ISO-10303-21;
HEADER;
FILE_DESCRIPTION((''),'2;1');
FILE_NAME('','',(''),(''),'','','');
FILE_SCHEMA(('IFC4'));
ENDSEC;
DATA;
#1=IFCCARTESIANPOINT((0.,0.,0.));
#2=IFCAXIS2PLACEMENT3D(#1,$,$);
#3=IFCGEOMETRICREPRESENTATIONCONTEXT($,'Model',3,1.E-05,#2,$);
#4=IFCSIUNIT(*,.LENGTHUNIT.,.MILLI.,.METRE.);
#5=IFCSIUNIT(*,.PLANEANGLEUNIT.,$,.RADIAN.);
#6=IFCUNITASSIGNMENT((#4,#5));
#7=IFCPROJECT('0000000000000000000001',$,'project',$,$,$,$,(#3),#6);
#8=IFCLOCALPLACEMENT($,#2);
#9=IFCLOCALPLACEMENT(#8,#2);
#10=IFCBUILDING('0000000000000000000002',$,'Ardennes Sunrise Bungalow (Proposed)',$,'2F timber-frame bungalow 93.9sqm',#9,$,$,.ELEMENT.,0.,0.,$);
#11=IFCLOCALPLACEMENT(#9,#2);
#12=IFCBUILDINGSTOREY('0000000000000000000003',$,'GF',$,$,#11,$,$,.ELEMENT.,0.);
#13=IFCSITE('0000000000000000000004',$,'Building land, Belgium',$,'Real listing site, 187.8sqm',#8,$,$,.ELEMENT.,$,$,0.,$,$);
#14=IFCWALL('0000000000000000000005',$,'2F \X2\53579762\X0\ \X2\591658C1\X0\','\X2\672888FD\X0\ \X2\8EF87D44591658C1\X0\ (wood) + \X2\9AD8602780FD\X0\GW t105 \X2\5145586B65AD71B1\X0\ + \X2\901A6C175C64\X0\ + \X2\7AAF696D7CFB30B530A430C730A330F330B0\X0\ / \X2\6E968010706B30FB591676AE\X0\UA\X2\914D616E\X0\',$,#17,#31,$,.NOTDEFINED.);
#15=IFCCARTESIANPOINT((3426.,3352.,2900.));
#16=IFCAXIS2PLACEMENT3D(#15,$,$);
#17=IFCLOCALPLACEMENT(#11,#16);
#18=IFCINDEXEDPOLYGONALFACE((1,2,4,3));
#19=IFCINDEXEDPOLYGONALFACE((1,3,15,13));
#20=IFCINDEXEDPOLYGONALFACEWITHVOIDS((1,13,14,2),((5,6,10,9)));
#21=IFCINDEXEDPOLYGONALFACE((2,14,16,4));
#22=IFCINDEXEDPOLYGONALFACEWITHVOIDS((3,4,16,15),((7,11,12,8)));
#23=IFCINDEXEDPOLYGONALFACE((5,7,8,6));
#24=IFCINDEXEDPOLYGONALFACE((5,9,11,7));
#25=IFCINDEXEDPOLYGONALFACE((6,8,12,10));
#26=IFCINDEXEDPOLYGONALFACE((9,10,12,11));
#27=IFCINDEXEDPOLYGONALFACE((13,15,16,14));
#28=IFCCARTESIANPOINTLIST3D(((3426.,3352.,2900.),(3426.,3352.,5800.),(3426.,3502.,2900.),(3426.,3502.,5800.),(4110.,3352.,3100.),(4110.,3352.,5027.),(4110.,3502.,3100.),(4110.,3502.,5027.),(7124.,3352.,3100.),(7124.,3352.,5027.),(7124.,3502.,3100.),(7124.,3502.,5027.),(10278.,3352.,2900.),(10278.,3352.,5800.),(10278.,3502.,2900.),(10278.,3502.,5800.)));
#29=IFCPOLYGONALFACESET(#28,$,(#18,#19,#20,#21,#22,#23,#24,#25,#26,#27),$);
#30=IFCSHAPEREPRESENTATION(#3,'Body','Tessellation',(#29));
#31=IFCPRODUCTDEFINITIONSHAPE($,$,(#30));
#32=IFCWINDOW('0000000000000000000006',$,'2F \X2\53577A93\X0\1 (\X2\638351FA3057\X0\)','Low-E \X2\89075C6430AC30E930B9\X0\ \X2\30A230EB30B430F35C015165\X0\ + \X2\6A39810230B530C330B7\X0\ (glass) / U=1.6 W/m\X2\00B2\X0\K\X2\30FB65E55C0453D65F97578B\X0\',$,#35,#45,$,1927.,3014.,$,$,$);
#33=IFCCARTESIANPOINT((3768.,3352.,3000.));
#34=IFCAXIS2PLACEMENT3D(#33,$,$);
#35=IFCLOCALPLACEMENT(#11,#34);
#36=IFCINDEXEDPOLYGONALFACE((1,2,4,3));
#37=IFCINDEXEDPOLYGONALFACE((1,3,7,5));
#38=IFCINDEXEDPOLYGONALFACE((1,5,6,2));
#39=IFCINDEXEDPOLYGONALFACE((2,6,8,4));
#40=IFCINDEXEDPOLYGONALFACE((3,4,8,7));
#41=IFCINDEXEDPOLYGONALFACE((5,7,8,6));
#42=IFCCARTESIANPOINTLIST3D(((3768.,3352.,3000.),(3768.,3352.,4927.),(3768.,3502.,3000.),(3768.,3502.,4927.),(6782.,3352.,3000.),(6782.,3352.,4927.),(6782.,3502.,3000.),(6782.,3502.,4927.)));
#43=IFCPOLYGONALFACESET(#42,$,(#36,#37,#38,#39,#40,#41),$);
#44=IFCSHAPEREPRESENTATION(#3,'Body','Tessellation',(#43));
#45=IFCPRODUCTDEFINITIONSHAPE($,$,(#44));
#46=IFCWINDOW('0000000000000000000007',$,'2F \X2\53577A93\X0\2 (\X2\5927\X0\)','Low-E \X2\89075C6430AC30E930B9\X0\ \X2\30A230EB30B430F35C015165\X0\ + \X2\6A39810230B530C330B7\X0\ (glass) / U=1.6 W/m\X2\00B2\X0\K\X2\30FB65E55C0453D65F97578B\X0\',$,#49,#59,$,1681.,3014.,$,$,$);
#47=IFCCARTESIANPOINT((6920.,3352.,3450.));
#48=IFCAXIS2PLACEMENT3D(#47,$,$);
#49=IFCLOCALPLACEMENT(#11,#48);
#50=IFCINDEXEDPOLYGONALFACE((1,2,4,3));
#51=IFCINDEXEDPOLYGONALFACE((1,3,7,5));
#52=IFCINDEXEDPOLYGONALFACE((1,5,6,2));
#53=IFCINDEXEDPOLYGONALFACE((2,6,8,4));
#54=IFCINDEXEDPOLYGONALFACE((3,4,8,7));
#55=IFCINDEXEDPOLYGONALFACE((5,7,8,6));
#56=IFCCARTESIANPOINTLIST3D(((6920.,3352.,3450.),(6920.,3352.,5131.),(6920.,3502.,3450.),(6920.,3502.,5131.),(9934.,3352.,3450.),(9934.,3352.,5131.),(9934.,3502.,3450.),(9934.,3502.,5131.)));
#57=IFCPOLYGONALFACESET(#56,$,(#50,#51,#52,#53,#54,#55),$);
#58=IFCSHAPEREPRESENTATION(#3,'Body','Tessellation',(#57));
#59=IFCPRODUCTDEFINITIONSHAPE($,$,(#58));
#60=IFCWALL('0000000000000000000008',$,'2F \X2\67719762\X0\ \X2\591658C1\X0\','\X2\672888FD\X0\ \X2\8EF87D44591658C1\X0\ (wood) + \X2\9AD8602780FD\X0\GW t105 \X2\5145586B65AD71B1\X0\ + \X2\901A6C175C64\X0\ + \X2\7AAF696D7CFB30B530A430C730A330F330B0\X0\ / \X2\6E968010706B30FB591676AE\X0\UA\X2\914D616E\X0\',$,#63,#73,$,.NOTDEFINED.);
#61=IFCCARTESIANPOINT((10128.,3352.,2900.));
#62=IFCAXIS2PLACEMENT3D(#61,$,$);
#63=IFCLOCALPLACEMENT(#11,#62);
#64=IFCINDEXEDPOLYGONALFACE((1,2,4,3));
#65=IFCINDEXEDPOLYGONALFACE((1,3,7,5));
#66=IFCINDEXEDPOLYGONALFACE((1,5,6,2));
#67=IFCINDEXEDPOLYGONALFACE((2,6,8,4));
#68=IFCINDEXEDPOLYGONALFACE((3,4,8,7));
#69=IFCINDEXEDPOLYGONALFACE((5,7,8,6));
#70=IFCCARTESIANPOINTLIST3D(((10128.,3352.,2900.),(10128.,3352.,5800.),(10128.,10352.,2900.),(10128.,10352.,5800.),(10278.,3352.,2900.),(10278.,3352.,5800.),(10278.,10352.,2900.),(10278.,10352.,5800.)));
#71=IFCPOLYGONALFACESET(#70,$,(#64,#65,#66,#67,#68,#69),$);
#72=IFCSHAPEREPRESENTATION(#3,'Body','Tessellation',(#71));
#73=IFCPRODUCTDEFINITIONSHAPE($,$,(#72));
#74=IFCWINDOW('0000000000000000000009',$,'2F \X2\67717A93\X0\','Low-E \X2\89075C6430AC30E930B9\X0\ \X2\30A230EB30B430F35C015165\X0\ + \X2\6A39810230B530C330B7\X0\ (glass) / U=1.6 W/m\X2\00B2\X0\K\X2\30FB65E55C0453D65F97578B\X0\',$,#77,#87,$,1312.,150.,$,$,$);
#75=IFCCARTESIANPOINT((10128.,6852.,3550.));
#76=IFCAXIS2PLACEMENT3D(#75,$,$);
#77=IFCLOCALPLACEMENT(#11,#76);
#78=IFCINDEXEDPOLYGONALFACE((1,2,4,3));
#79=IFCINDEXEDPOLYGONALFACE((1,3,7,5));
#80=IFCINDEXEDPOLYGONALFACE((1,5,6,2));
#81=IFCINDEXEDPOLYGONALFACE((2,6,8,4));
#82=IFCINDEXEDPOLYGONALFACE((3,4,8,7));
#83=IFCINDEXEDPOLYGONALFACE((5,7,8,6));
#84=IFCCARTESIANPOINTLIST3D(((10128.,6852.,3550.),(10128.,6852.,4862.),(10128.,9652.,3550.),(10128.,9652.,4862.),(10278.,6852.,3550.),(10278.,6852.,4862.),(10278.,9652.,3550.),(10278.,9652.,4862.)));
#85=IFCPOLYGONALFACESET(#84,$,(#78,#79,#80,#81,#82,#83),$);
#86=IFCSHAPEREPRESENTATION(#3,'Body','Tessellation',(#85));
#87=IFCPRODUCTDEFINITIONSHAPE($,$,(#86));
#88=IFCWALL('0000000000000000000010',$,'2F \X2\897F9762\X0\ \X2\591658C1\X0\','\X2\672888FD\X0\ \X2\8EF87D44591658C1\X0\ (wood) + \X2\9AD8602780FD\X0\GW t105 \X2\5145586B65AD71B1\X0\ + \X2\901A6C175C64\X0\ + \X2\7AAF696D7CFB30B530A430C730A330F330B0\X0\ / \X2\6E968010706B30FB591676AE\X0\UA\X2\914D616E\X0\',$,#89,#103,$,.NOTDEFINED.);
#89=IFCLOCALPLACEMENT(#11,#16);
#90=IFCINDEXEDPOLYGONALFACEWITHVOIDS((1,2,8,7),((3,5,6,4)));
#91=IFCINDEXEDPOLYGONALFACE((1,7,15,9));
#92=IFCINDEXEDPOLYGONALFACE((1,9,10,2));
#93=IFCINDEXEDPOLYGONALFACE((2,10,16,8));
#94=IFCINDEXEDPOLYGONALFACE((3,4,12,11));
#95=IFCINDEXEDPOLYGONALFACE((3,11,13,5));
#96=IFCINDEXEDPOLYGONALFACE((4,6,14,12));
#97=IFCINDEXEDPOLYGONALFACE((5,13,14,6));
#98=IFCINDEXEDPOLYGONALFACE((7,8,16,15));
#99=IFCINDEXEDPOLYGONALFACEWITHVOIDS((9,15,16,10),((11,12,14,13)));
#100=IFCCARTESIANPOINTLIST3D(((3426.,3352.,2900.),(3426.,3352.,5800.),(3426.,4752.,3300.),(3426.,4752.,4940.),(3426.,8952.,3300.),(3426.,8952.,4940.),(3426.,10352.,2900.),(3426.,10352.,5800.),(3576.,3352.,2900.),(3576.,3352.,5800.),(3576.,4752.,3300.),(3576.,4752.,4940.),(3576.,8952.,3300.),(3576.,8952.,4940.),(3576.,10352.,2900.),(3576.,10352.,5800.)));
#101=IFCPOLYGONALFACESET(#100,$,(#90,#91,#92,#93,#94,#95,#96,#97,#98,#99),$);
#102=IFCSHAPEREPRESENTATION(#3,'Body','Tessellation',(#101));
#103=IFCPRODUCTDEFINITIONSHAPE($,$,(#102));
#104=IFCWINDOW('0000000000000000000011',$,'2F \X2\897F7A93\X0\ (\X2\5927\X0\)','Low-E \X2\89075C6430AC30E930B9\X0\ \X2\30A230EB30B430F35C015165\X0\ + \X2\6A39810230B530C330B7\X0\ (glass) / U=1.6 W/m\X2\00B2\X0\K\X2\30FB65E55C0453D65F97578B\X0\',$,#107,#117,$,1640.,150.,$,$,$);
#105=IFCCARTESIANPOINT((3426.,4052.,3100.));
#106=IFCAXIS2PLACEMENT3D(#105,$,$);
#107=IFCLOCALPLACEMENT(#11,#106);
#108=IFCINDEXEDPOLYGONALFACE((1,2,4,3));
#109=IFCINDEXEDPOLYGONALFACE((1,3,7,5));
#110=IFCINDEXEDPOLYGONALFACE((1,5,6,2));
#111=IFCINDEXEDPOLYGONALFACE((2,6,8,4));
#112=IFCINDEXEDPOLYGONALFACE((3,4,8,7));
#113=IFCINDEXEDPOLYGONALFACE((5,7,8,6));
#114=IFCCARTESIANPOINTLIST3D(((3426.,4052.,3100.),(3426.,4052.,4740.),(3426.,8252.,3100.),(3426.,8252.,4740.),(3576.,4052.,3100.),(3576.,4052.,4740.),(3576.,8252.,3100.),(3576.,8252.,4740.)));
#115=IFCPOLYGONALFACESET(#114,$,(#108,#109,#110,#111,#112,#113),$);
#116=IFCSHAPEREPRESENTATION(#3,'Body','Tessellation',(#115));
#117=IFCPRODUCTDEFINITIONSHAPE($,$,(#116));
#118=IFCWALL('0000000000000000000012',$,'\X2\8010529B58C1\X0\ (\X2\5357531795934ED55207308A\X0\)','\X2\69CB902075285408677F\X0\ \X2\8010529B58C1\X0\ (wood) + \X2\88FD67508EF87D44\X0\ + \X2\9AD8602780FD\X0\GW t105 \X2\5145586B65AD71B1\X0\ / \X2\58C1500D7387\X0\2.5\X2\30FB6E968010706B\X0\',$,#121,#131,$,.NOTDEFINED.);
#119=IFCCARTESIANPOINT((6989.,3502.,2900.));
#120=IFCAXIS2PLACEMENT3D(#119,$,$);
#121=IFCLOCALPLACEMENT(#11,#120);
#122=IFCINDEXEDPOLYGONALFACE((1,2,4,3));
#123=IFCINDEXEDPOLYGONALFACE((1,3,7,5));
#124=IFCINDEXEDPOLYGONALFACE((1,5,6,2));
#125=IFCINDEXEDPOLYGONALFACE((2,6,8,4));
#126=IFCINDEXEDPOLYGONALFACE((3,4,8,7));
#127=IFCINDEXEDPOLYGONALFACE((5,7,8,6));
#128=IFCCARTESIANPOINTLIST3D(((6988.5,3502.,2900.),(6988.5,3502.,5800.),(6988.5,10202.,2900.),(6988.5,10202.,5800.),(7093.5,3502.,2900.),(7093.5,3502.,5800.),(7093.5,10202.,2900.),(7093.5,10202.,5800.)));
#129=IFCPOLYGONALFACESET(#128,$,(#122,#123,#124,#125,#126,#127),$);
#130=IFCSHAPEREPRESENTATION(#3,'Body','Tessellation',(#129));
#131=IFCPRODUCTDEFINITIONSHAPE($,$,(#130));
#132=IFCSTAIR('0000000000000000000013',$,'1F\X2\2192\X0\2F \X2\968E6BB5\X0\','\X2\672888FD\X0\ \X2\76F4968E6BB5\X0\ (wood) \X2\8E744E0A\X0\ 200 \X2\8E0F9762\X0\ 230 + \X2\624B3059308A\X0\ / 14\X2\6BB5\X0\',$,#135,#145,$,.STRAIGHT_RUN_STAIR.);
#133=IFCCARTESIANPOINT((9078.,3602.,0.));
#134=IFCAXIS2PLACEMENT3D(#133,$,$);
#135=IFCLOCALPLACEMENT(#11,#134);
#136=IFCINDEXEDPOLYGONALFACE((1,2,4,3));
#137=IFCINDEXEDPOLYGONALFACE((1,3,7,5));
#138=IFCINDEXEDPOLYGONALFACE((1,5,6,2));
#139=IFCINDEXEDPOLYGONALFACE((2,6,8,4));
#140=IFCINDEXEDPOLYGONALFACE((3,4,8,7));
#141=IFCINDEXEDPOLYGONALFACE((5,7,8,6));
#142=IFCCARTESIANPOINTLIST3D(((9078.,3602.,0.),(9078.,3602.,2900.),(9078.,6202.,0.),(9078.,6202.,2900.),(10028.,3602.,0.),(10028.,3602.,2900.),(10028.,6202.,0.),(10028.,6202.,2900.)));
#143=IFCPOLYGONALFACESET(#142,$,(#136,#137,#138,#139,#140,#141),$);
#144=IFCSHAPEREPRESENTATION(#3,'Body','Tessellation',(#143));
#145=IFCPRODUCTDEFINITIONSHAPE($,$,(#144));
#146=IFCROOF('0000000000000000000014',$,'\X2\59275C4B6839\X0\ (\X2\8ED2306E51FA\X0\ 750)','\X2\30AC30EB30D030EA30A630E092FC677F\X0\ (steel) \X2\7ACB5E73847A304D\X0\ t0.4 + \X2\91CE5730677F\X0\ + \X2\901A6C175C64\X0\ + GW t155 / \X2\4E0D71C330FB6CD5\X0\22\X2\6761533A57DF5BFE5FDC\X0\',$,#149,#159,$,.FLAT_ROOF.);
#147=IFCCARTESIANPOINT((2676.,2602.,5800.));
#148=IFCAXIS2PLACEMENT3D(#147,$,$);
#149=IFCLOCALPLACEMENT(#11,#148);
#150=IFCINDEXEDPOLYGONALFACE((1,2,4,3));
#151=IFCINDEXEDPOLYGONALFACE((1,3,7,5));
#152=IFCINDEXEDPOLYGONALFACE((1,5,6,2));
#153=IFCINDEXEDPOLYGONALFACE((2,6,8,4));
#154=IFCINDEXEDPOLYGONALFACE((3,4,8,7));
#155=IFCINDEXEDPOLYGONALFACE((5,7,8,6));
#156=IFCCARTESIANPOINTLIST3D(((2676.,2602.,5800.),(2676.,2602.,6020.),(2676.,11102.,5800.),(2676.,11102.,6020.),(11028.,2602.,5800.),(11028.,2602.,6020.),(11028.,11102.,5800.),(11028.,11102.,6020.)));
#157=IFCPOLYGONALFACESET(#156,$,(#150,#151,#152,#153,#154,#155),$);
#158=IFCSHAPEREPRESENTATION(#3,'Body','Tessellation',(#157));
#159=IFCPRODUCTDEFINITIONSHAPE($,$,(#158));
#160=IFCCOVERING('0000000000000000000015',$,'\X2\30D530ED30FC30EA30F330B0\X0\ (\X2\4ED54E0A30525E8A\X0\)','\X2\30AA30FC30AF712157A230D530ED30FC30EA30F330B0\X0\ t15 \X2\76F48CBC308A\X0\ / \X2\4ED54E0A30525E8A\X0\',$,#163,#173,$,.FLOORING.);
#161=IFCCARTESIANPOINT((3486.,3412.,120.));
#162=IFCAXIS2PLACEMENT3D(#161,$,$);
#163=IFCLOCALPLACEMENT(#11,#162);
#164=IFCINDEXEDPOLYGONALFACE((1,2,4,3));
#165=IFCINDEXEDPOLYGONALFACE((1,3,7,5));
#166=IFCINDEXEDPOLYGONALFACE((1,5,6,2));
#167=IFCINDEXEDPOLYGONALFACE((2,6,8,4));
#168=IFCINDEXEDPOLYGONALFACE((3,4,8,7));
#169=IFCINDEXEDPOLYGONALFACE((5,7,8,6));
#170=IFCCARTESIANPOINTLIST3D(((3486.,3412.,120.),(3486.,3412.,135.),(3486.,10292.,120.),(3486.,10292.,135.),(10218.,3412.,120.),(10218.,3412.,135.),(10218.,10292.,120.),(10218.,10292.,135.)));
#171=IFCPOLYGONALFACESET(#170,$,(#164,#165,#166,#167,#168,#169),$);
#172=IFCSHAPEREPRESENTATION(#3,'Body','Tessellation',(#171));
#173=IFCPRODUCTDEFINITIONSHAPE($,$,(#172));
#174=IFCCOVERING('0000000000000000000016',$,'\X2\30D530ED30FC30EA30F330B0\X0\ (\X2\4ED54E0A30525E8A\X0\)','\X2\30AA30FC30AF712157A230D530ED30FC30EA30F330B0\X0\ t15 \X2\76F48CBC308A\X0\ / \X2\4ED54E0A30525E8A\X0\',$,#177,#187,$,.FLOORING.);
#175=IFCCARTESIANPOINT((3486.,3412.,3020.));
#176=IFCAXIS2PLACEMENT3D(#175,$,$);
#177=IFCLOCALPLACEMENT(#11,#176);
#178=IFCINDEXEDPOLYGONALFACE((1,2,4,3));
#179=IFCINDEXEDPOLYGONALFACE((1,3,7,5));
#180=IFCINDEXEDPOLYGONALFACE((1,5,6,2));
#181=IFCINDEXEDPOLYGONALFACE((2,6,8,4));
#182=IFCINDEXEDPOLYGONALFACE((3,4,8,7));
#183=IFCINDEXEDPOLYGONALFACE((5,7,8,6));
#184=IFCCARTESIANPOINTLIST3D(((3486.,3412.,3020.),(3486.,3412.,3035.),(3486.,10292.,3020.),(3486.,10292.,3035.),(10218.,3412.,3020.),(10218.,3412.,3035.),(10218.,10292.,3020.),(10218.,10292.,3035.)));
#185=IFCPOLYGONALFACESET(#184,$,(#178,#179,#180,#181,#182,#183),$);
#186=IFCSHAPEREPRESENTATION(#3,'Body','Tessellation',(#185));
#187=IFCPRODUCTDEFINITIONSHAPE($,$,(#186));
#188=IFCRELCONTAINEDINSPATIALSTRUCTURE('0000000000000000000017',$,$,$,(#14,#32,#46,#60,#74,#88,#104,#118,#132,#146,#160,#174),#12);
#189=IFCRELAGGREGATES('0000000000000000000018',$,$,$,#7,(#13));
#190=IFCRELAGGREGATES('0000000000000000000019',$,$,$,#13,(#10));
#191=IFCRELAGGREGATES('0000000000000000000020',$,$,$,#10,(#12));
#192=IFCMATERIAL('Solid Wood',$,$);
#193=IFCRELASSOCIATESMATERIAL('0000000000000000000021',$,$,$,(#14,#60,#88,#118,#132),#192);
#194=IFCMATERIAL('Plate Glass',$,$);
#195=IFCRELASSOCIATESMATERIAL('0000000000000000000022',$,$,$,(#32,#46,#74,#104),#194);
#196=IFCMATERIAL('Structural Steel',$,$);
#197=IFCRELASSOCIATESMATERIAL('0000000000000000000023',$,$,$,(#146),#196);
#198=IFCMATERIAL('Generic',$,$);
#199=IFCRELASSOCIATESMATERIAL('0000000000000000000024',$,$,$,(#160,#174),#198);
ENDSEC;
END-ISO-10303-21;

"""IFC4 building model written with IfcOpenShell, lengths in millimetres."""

from ifc_helpers import new_model, si_unit, frame, frame_2d, origin, place, context, project, spatial, rectangle, extrude, material, element, fill, save


model = new_model("IFC4")

# Units and contexts
model_context = context("Model", 3, precision=1e-05, world=origin())
ifc_project = project(units=[si_unit("LENGTHUNIT", "METRE", prefix="MILLI"), si_unit("PLANEANGLEUNIT", "RADIAN")], contexts=[model_context])

# Site, building, storey
site_placement = place(None, origin())
site = spatial("IfcSite", under=ifc_project, at=site_placement, Name="Building land, Belgium", ObjectType="Real listing site, 187.8sqm", CompositionType="ELEMENT", RefElevation=0.0)
building_placement = place(site_placement, origin())
building = spatial("IfcBuilding", under=site, at=building_placement, Name="Ardennes Sunrise Bungalow (Proposed)", ObjectType="2F timber-frame bungalow 93.9sqm", CompositionType="ELEMENT", ElevationOfRefHeight=0.0, ElevationOfTerrain=0.0)
storey_placement = place(building_placement, origin())
storey = spatial("IfcBuildingStorey", under=building, at=storey_placement, Name="GF", CompositionType="ELEMENT", Elevation=0.0)

# Shared definitions
ifc_material_1 = material(Name="Solid Wood")

# Shared definitions
ifc_material_2 = material(Name="Plate Glass")

# Wall, openings, windows
wall_1_placement = place(storey_placement, frame((3426.0, 3352.0, 2900.0)))
wall_1 = element("IfcWall", 1, at=wall_1_placement, inside=storey, material=ifc_material_1, Name="2F 南面 外壁", Description="木製 軸組外壁 (wood) + 高性能GW t105 充填断熱 + 通気層 + 窯業系サイディング / 準耐火・外皮UA配慮", PredefinedType="NOTDEFINED", context=model_context, shape_type="SweptSolid", body=[
    extrude(rectangle(XDim=6852.0, YDim=150.0, at=frame_2d((3426.0, 75.0))), frame((3426.0, 3352.0, 2900.0)), (0.0, 0.0, 1.0), 2900.0),
])
opening_1_placement = place(storey_placement, frame((3768.0, 3352.0, 3000.0)))
opening_1 = element("IfcOpeningElement", 2, at=opening_1_placement, cuts=wall_1, PredefinedType="NOTDEFINED", context=model_context, shape_type="SweptSolid", body=[
    extrude(rectangle(XDim=3014.0, YDim=150.0, at=frame_2d((1507.0, 75.0))), frame((3768.0, 3352.0, 3000.0)), (0.0, 0.0, 1.0), 1927.0),
])
opening_2_placement = place(storey_placement, frame((6920.0, 3352.0, 3450.0)))
opening_2 = element("IfcOpeningElement", 3, at=opening_2_placement, cuts=wall_1, PredefinedType="NOTDEFINED", context=model_context, shape_type="SweptSolid", body=[
    extrude(rectangle(XDim=3014.0, YDim=150.0, at=frame_2d((1507.0, 75.0))), frame((6920.0, 3352.0, 3450.0)), (0.0, 0.0, 1.0), 1681.0),
])
window_1_placement = place(storey_placement, frame((3768.0, 3352.0, 3000.0)))
window_1 = element("IfcWindow", 4, at=window_1_placement, inside=storey, material=ifc_material_2, Name="2F 南窓1 (掃出し)", Description="Low-E 複層ガラス アルゴン封入 + 樹脂サッシ (glass) / U=1.6 W/m²K・日射取得型", OverallHeight=1927.0, OverallWidth=3014.0, context=model_context, shape_type="SweptSolid", body=[
    extrude(rectangle(XDim=3014.0, YDim=150.0, at=frame_2d((1507.0, 75.0))), frame((3768.0, 3352.0, 3000.0)), (0.0, 0.0, 1.0), 1927.0),
])
fill(opening_1, window_1)
window_2_placement = place(storey_placement, frame((6920.0, 3352.0, 3450.0)))
window_2 = element("IfcWindow", 5, at=window_2_placement, inside=storey, material=ifc_material_2, Name="2F 南窓2 (大)", Description="Low-E 複層ガラス アルゴン封入 + 樹脂サッシ (glass) / U=1.6 W/m²K・日射取得型", OverallHeight=1681.0, OverallWidth=3014.0, context=model_context, shape_type="SweptSolid", body=[
    extrude(rectangle(XDim=3014.0, YDim=150.0, at=frame_2d((1507.0, 75.0))), frame((6920.0, 3352.0, 3450.0)), (0.0, 0.0, 1.0), 1681.0),
])
fill(opening_2, window_2)

# Walls, openings, windows
wall_2_placement = place(storey_placement, frame((10128.0, 3352.0, 2900.0)))
wall_2 = element("IfcWall", 6, at=wall_2_placement, inside=storey, material=ifc_material_1, Name="2F 東面 外壁", Description="木製 軸組外壁 (wood) + 高性能GW t105 充填断熱 + 通気層 + 窯業系サイディング / 準耐火・外皮UA配慮", PredefinedType="NOTDEFINED", context=model_context, shape_type="SweptSolid", body=[
    extrude(rectangle(XDim=150.0, YDim=7000.0, at=frame_2d((75.0, 3500.0))), frame((10128.0, 3352.0, 2900.0)), (0.0, 0.0, 1.0), 2900.0),
])
opening_3_placement = place(storey_placement, frame((10128.0, 6852.0, 3550.0)))
opening_3 = element("IfcOpeningElement", 7, at=opening_3_placement, cuts=wall_2, PredefinedType="NOTDEFINED", context=model_context, shape_type="SweptSolid", body=[
    extrude(rectangle(XDim=150.0, YDim=2800.0, at=frame_2d((75.0, 1400.0))), frame((10128.0, 6852.0, 3550.0)), (0.0, 0.0, 1.0), 1312.0),
])
window_3_placement = place(storey_placement, frame((10128.0, 6852.0, 3550.0)))
window_3 = element("IfcWindow", 8, at=window_3_placement, inside=storey, material=ifc_material_2, Name="2F 東窓", Description="Low-E 複層ガラス アルゴン封入 + 樹脂サッシ (glass) / U=1.6 W/m²K・日射取得型", OverallHeight=1312.0, OverallWidth=150.0, context=model_context, shape_type="SweptSolid", body=[
    extrude(rectangle(XDim=150.0, YDim=2800.0, at=frame_2d((75.0, 1400.0))), frame((10128.0, 6852.0, 3550.0)), (0.0, 0.0, 1.0), 1312.0),
])
fill(opening_3, window_3)
wall_3_placement = place(storey_placement, frame((3426.0, 3352.0, 2900.0)))
wall_3 = element("IfcWall", 9, at=wall_3_placement, inside=storey, material=ifc_material_1, Name="2F 西面 外壁", Description="木製 軸組外壁 (wood) + 高性能GW t105 充填断熱 + 通気層 + 窯業系サイディング / 準耐火・外皮UA配慮", PredefinedType="NOTDEFINED", context=model_context, shape_type="SweptSolid", body=[
    extrude(rectangle(XDim=150.0, YDim=7000.0, at=frame_2d((75.0, 3500.0))), frame((3426.0, 3352.0, 2900.0)), (0.0, 0.0, 1.0), 2900.0),
])
opening_4_placement = place(storey_placement, frame((3426.0, 4052.0, 3100.0)))
opening_4 = element("IfcOpeningElement", 10, at=opening_4_placement, cuts=wall_3, PredefinedType="NOTDEFINED", context=model_context, shape_type="SweptSolid", body=[
    extrude(rectangle(XDim=150.0, YDim=4200.0, at=frame_2d((75.0, 2100.0))), frame((3426.0, 4052.0, 3100.0)), (0.0, 0.0, 1.0), 1640.0),
])
window_4_placement = place(storey_placement, frame((3426.0, 4052.0, 3100.0)))
window_4 = element("IfcWindow", 11, at=window_4_placement, inside=storey, material=ifc_material_2, Name="2F 西窓 (大)", Description="Low-E 複層ガラス アルゴン封入 + 樹脂サッシ (glass) / U=1.6 W/m²K・日射取得型", OverallHeight=1640.0, OverallWidth=150.0, context=model_context, shape_type="SweptSolid", body=[
    extrude(rectangle(XDim=150.0, YDim=4200.0, at=frame_2d((75.0, 2100.0))), frame((3426.0, 4052.0, 3100.0)), (0.0, 0.0, 1.0), 1640.0),
])
fill(opening_4, window_4)

# Wall
wall_4_placement = place(storey_placement, frame((6989.0, 3502.0, 2900.0)))
element("IfcWall", 12, at=wall_4_placement, inside=storey, material=ifc_material_1, Name="耐力壁 (南北間仕切り)", Description="構造用合板 耐力壁 (wood) + 製材軸組 + 高性能GW t105 充填断熱 / 壁倍率2.5・準耐火", PredefinedType="NOTDEFINED", context=model_context, shape_type="SweptSolid", body=[
    extrude(rectangle(XDim=105.0, YDim=6700.0, at=frame_2d((52.0, 3350.0))), frame((6989.0, 3502.0, 2900.0)), (0.0, 0.0, 1.0), 2900.0),
])

# Stair
stair_placement = place(storey_placement, frame((9078.0, 3602.0, 0.0)))
element("IfcStair", 13, at=stair_placement, inside=storey, material=ifc_material_1, Name="1F→2F 階段", Description="木製 直階段 (wood) 蹴上 200 踏面 230 + 手すり / 14段", PredefinedType="STRAIGHT_RUN_STAIR", context=model_context, shape_type="SweptSolid", body=[
    extrude(rectangle(XDim=950.0, YDim=2600.0, at=frame_2d((475.0, 1300.0))), frame((9078.0, 3602.0, 0.0)), (0.0, 0.0, 1.0), 2900.0),
])

# Roof
ifc_material_3 = material(Name="Structural Steel")
roof_placement = place(storey_placement, frame((2676.0, 2602.0, 5800.0)))
element("IfcRoof", 14, at=roof_placement, inside=storey, material=ifc_material_3, Name="大屋根 (軒の出 750)", Description="ガルバリウム鋼板 (steel) 立平葺き t0.4 + 野地板 + 通気層 + GW t155 / 不燃・法22条区域対応", PredefinedType="FLAT_ROOF", context=model_context, shape_type="SweptSolid", body=[
    extrude(rectangle(XDim=8352.0, YDim=8500.0, at=frame_2d((4176.0, 4250.0))), frame((2676.0, 2602.0, 5800.0)), (0.0, 0.0, 1.0), 220.0),
])

# Coverings
ifc_material_4 = material(Name="Generic")
covering_1_placement = place(storey_placement, frame((3486.0, 3412.0, 120.0)))
element("IfcCovering", 15, at=covering_1_placement, inside=storey, material=ifc_material_4, Name="フローリング (仕上げ床)", Description="オーク無垢フローリング t15 直貼り / 仕上げ床", PredefinedType="FLOORING", context=model_context, shape_type="SweptSolid", body=[
    extrude(rectangle(XDim=6732.0, YDim=6880.0, at=frame_2d((3366.0, 3440.0))), frame((3486.0, 3412.0, 120.0)), (0.0, 0.0, 1.0), 15.0),
])
covering_2_placement = place(storey_placement, frame((3486.0, 3412.0, 3020.0)))
element("IfcCovering", 16, at=covering_2_placement, inside=storey, material=ifc_material_4, Name="フローリング (仕上げ床)", Description="オーク無垢フローリング t15 直貼り / 仕上げ床", PredefinedType="FLOORING", context=model_context, shape_type="SweptSolid", body=[
    extrude(rectangle(XDim=6732.0, YDim=6880.0, at=frame_2d((3366.0, 3440.0))), frame((3486.0, 3412.0, 3020.0)), (0.0, 0.0, 1.0), 15.0),
])

save(model, "model.ifc")
